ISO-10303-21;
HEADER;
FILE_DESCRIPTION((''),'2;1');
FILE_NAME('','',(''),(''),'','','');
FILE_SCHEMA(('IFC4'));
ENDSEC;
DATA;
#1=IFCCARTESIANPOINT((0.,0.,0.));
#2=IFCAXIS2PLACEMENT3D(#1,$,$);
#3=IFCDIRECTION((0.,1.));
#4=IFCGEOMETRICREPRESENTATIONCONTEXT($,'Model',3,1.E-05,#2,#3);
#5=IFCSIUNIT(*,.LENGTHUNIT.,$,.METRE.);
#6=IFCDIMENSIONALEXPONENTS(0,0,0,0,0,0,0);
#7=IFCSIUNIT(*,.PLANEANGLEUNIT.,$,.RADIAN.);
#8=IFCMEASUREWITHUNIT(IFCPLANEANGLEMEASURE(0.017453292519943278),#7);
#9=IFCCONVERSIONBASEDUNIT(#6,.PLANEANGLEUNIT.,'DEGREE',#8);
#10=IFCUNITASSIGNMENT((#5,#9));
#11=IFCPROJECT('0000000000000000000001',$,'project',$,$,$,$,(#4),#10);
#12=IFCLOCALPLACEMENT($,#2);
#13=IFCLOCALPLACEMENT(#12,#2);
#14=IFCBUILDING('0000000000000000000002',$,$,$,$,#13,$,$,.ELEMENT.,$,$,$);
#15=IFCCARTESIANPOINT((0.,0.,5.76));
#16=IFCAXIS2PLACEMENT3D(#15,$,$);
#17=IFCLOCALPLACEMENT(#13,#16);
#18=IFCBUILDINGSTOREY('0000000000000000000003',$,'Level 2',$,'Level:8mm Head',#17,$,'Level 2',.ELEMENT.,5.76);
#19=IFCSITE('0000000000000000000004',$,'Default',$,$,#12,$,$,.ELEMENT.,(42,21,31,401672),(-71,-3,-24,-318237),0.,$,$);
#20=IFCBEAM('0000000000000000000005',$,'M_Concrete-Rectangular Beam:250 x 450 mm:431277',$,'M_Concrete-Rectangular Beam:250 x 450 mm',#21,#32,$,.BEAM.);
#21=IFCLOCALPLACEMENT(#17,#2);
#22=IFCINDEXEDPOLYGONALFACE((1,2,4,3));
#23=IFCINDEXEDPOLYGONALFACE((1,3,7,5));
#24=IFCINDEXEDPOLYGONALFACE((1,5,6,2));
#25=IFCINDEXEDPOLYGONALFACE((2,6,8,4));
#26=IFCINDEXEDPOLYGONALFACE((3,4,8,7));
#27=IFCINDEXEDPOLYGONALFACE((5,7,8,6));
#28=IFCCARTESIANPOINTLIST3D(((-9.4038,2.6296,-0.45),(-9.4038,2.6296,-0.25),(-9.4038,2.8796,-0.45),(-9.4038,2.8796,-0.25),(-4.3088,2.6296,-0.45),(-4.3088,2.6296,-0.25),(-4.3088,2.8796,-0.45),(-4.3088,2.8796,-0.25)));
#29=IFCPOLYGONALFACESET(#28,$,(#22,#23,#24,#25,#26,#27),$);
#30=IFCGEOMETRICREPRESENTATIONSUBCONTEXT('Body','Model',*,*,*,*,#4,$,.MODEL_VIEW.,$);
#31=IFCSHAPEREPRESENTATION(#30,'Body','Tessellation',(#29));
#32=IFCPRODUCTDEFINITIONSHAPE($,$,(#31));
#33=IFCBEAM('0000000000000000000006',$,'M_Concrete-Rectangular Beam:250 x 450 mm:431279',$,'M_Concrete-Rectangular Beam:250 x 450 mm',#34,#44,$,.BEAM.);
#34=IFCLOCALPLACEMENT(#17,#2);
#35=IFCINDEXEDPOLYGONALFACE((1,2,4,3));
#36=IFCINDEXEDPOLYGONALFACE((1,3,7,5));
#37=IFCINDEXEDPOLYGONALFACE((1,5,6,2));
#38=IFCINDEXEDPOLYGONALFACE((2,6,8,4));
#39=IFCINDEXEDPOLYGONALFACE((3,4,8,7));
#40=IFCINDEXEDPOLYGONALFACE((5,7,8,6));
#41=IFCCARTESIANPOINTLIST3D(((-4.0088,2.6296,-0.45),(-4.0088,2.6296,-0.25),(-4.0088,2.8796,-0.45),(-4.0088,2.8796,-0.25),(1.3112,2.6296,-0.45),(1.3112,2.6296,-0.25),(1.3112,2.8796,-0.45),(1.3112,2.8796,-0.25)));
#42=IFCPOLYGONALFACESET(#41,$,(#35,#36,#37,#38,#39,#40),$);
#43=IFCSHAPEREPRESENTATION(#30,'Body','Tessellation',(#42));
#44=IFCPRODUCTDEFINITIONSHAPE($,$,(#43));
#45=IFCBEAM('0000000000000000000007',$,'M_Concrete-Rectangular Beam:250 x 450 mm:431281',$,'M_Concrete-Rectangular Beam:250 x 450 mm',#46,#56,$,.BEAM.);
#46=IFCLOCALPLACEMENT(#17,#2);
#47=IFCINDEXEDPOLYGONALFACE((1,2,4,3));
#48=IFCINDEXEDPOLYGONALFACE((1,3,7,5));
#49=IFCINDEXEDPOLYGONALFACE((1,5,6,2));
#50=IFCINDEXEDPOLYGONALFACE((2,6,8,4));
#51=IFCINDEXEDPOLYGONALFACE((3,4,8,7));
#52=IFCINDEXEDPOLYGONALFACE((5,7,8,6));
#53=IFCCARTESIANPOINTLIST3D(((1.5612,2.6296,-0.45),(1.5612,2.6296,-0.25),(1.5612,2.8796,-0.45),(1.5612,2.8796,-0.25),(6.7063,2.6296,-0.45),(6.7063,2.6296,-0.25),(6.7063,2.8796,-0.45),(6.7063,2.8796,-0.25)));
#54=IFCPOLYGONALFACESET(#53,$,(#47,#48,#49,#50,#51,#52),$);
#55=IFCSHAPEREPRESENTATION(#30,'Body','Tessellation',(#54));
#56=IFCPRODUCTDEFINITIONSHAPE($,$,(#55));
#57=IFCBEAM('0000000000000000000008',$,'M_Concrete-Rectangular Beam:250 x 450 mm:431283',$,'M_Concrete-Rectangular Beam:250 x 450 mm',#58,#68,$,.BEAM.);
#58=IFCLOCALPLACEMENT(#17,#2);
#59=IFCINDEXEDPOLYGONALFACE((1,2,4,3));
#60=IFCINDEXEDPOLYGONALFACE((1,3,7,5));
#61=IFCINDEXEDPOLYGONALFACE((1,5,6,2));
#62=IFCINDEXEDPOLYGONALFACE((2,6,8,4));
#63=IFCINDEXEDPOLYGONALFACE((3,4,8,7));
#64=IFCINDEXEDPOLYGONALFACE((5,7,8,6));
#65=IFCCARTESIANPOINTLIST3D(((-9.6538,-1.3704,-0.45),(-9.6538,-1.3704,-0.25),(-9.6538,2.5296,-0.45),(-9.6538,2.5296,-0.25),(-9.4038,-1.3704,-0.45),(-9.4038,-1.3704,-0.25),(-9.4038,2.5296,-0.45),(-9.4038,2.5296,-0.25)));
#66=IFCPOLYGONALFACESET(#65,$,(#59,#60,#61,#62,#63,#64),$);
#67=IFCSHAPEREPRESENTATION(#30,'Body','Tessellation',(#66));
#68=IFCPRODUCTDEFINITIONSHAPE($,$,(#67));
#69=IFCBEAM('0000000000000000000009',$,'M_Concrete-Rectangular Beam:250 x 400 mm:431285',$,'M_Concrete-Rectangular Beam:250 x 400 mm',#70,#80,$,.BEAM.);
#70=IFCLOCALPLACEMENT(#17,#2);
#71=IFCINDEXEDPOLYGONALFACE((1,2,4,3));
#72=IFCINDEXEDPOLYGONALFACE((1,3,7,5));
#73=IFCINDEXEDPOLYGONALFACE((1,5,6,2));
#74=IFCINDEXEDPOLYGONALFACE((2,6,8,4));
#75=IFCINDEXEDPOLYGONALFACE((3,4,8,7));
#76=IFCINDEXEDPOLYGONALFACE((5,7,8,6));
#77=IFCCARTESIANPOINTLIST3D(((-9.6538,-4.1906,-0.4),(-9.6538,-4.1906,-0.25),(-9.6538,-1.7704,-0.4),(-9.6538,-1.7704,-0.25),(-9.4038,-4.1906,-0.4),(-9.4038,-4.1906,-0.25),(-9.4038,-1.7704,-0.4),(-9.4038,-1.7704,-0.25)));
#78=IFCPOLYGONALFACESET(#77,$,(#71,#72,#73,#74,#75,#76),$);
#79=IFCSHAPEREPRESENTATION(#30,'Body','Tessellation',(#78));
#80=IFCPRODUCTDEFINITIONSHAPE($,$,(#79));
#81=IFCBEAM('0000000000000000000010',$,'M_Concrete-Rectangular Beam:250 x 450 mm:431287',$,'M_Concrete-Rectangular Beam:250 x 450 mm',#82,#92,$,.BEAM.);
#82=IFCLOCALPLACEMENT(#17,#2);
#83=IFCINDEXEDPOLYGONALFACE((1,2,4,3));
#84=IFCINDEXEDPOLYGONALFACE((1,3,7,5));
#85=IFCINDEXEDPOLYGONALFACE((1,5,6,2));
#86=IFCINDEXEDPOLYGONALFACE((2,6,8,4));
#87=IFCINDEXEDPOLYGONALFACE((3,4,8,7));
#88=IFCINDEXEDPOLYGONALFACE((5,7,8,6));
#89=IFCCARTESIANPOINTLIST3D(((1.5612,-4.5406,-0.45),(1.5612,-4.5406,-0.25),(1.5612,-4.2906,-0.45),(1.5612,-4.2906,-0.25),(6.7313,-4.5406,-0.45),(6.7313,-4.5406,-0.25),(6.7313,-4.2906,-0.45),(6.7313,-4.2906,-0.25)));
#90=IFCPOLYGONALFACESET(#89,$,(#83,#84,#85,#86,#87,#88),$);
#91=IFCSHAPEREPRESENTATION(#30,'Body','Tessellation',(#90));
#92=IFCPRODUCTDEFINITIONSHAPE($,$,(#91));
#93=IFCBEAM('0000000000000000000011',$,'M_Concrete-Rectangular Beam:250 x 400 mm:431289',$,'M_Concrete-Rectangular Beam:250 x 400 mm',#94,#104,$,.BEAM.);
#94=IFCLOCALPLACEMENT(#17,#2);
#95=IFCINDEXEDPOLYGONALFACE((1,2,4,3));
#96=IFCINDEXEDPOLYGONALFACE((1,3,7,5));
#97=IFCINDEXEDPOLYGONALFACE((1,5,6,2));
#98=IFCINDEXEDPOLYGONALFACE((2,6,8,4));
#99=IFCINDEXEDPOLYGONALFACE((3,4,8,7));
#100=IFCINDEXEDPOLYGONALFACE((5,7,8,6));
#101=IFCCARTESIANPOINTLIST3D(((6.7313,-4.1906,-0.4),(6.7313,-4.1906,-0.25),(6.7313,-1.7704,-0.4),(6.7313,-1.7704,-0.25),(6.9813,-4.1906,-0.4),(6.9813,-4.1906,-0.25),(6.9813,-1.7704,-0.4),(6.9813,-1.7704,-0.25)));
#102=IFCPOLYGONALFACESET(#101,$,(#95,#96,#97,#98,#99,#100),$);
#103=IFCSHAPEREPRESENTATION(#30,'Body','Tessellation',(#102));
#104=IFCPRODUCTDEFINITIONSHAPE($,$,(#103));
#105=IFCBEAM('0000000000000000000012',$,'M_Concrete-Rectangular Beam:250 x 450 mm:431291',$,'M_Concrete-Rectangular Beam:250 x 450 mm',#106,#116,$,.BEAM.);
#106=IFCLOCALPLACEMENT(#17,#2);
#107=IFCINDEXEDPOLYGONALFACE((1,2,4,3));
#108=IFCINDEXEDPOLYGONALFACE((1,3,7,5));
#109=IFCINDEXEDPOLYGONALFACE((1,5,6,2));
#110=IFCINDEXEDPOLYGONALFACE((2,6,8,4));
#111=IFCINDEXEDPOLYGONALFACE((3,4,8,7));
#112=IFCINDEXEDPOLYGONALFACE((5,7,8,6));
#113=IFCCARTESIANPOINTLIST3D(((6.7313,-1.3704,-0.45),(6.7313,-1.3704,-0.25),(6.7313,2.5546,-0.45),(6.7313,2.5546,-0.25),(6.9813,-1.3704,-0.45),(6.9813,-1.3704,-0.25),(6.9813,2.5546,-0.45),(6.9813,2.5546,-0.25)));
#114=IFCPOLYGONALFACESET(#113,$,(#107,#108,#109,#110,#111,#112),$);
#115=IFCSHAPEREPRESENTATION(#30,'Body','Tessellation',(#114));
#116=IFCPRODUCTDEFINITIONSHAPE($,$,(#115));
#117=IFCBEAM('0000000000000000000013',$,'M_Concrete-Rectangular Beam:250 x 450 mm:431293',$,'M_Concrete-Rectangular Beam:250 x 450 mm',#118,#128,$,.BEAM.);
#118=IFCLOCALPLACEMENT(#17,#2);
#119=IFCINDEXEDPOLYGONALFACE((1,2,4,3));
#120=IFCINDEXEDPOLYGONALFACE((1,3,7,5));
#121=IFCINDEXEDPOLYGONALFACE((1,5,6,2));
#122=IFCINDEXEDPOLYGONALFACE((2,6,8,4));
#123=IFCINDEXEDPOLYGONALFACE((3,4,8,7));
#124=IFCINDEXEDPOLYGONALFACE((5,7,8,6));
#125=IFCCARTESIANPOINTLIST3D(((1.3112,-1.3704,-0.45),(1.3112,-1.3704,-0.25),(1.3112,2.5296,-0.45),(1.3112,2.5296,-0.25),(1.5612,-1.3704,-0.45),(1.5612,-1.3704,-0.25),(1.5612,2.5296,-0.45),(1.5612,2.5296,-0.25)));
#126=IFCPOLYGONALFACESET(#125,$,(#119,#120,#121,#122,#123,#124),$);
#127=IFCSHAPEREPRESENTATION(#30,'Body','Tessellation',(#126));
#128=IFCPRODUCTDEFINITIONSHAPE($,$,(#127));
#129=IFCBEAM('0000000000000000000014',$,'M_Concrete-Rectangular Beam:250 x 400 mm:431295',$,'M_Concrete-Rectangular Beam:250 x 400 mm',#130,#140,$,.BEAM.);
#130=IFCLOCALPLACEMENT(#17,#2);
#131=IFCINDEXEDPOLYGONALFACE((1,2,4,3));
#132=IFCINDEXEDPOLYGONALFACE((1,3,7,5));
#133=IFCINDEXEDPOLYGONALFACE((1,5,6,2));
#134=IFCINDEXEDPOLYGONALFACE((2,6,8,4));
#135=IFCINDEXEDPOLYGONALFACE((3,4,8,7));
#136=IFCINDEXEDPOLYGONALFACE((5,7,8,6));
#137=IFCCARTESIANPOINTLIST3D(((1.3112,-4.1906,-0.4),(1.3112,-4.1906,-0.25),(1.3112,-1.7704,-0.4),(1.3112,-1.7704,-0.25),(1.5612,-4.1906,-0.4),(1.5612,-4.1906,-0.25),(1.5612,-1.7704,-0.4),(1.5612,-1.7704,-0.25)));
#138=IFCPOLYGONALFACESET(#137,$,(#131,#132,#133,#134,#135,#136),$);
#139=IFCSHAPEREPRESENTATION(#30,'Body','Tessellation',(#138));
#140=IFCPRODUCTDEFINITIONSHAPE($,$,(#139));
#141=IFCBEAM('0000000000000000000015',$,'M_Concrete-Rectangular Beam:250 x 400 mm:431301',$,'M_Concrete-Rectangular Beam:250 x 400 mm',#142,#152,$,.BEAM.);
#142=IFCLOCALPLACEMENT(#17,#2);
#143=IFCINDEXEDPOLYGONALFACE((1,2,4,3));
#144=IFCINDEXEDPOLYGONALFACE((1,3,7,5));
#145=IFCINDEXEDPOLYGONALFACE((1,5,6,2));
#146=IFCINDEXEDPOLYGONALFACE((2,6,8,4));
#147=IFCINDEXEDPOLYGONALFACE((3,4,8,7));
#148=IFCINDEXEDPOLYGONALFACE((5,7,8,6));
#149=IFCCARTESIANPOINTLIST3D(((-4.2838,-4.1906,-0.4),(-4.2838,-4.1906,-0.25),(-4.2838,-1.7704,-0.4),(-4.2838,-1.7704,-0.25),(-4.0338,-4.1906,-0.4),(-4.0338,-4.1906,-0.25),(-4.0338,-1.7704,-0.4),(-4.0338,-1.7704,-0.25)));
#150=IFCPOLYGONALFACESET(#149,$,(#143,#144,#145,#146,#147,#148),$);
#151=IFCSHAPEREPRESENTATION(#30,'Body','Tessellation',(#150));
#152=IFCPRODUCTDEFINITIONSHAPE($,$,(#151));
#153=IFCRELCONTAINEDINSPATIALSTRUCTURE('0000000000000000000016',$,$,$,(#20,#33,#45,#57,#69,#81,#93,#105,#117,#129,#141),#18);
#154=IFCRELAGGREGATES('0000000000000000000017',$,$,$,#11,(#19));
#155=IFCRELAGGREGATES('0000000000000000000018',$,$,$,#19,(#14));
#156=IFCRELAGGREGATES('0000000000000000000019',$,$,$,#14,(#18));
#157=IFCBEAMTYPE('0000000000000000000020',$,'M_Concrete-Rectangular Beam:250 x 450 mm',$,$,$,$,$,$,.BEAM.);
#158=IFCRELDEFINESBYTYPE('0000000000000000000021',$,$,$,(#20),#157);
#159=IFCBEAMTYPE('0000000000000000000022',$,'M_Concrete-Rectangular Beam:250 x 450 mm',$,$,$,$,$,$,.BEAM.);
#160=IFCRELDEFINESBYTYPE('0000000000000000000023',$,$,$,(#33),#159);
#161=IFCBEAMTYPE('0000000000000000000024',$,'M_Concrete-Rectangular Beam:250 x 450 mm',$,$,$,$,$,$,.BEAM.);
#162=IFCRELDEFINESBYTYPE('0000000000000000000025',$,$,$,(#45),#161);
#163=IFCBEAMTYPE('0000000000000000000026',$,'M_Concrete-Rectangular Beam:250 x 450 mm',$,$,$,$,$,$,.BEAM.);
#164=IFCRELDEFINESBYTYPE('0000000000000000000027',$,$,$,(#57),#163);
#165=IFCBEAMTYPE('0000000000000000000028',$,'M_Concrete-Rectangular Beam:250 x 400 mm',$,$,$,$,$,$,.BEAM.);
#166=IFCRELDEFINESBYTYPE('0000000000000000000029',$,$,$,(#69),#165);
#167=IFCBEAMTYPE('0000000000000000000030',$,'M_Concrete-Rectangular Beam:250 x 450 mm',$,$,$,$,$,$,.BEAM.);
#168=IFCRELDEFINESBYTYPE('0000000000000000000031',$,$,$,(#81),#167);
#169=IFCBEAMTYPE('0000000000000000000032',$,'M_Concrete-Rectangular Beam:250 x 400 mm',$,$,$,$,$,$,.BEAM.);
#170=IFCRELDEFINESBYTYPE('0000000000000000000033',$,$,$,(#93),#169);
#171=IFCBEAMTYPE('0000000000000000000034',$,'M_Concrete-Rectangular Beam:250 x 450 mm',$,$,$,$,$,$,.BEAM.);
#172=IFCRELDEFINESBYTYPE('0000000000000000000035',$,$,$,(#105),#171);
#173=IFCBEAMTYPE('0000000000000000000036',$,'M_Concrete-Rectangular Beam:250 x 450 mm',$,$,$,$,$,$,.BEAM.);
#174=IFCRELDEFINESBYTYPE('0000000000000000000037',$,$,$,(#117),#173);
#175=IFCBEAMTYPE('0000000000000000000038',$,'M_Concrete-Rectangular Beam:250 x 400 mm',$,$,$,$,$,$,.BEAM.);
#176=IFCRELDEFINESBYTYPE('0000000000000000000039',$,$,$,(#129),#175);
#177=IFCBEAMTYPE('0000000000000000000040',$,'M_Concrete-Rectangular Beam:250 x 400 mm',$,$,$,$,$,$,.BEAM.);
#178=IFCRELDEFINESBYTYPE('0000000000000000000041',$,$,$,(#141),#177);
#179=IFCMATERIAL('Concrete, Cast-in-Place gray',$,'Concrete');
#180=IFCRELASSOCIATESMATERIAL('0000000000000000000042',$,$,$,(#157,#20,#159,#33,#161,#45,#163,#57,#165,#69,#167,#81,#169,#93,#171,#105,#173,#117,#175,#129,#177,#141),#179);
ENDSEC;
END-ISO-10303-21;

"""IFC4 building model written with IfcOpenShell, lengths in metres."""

from ifc_helpers import new_model, entity, si_unit, converted_unit, direction, frame, origin, place, context, subcontext, project, spatial, indexed_curve, outline, extrude, source, transform, mapped, material, type_object, type_shapes, element, save


model = new_model("IFC4")

# Units and contexts
model_context = context("Model", 3, precision=1e-05, world=origin(), true_north=direction((0.0, 1.0)))
body_context = subcontext(model_context, "Body", "Model", "MODEL_VIEW")
ifc_project = project(units=[si_unit("LENGTHUNIT", "METRE"), converted_unit("PLANEANGLEUNIT", "DEGREE", entity("IfcPlaneAngleMeasure", 0.017453292519943278), si_unit("PLANEANGLEUNIT", "RADIAN"), dimensions=[0, 0, 0, 0, 0, 0, 0])], contexts=[model_context])

# Site, building, storey
site_placement = place(None, origin())
site = spatial("IfcSite", under=ifc_project, at=site_placement, Name="Default", CompositionType="ELEMENT", RefLatitude=(42, 21, 31, 401672), RefLongitude=(-71, -3, -24, -318237), RefElevation=0.0)
building_placement = place(site_placement, origin())
building = spatial("IfcBuilding", under=site, at=building_placement, CompositionType="ELEMENT")
storey_placement = place(building_placement, frame((0.0, 0.0, 5.76)))
storey = spatial("IfcBuildingStorey", under=building, at=storey_placement, Name="Level 2", ObjectType="Level:8mm Head", LongName="Level 2", CompositionType="ELEMENT", Elevation=5.76)

# Beams
ifc_material = material(Name="Concrete, Cast-in-Place gray", Category="Concrete")
beam_type_1 = type_object("IfcBeamType", Name="M_Concrete-Rectangular Beam:250 x 450 mm", PredefinedType="BEAM", material=ifc_material)
shared_shape_1 = source(origin(), body_context, "Body", "SweptSolid", [
    extrude(outline(indexed_curve([(-0.1, -0.125), (0.1, -0.125), (0.1, 0.125), (-0.1, 0.125), (-0.1, -0.125)], self_intersect=False)), frame((-9.4038, 2.7546, 5.41), z_axis=(1.0, 0.0, 0.0), x_axis=(0.0, 0.0, -1.0)), (0.0, 0.0, 1.0), 5.095),
])
type_shapes(beam_type_1, [shared_shape_1])
beam_1_placement = place(storey_placement, frame((0.0, 0.0, -5.76)))
element("IfcBeam", 1, at=beam_1_placement, inside=storey, type_object=beam_type_1, material=ifc_material, Name="M_Concrete-Rectangular Beam:250 x 450 mm:431277", ObjectType="M_Concrete-Rectangular Beam:250 x 450 mm", PredefinedType="BEAM", context=body_context, shape_type="MappedRepresentation", body=[
    mapped(shared_shape_1, transform((0.0, 0.0, 0.0), scale=1.0)),
])
beam_type_2 = type_object("IfcBeamType", Name="M_Concrete-Rectangular Beam:250 x 450 mm", PredefinedType="BEAM", material=ifc_material)
shared_shape_2 = source(origin(), body_context, "Body", "SweptSolid", [
    extrude(outline(indexed_curve([(-0.1, -0.125), (0.1, -0.125), (0.1, 0.125), (-0.1, 0.125), (-0.1, -0.125)], self_intersect=False)), frame((-4.0088, 2.7546, 5.41), z_axis=(1.0, 0.0, 0.0), x_axis=(0.0, 0.0, -1.0)), (0.0, 0.0, 1.0), 5.32),
])
type_shapes(beam_type_2, [shared_shape_2])
beam_2_placement = place(storey_placement, frame((0.0, 0.0, -5.76)))
element("IfcBeam", 2, at=beam_2_placement, inside=storey, type_object=beam_type_2, material=ifc_material, Name="M_Concrete-Rectangular Beam:250 x 450 mm:431279", ObjectType="M_Concrete-Rectangular Beam:250 x 450 mm", PredefinedType="BEAM", context=body_context, shape_type="MappedRepresentation", body=[
    mapped(shared_shape_2, transform((0.0, 0.0, 0.0), scale=1.0)),
])
beam_type_3 = type_object("IfcBeamType", Name="M_Concrete-Rectangular Beam:250 x 450 mm", PredefinedType="BEAM", material=ifc_material)
shared_shape_3 = source(origin(), body_context, "Body", "SweptSolid", [
    extrude(outline(indexed_curve([(-0.1, -0.125), (0.1, -0.125), (0.1, 0.125), (-0.1, 0.125), (-0.1, -0.125)], self_intersect=False)), frame((1.5612, 2.7546, 5.41), z_axis=(1.0, 0.0, 0.0), x_axis=(0.0, 0.0, -1.0)), (0.0, 0.0, 1.0), 5.1451),
])
type_shapes(beam_type_3, [shared_shape_3])
beam_3_placement = place(storey_placement, frame((0.0, 0.0, -5.76)))
element("IfcBeam", 3, at=beam_3_placement, inside=storey, type_object=beam_type_3, material=ifc_material, Name="M_Concrete-Rectangular Beam:250 x 450 mm:431281", ObjectType="M_Concrete-Rectangular Beam:250 x 450 mm", PredefinedType="BEAM", context=body_context, shape_type="MappedRepresentation", body=[
    mapped(shared_shape_3, transform((0.0, 0.0, 0.0), scale=1.0)),
])
beam_type_4 = type_object("IfcBeamType", Name="M_Concrete-Rectangular Beam:250 x 450 mm", PredefinedType="BEAM", material=ifc_material)
shared_shape_4 = source(origin(), body_context, "Body", "SweptSolid", [
    extrude(outline(indexed_curve([(-0.125, -0.1), (0.125, -0.1), (0.125, 0.1), (-0.125, 0.1), (-0.125, -0.1)], self_intersect=False)), frame((-9.5288, 2.5296, 5.41), z_axis=(0.0, -1.0, 0.0), x_axis=(-1.0, 0.0, 0.0)), (0.0, 0.0, 1.0), 3.9),
])
type_shapes(beam_type_4, [shared_shape_4])
beam_4_placement = place(storey_placement, frame((0.0, 0.0, -5.76)))
element("IfcBeam", 4, at=beam_4_placement, inside=storey, type_object=beam_type_4, material=ifc_material, Name="M_Concrete-Rectangular Beam:250 x 450 mm:431283", ObjectType="M_Concrete-Rectangular Beam:250 x 450 mm", PredefinedType="BEAM", context=body_context, shape_type="MappedRepresentation", body=[
    mapped(shared_shape_4, transform((0.0, 0.0, 0.0), scale=1.0)),
])
beam_type_5 = type_object("IfcBeamType", Name="M_Concrete-Rectangular Beam:250 x 400 mm", PredefinedType="BEAM", material=ifc_material)
shared_shape_5 = source(origin(), body_context, "Body", "SweptSolid", [
    extrude(outline(indexed_curve([(-0.125, -0.075), (0.125, -0.075), (0.125, 0.075), (-0.125, 0.075), (-0.125, -0.075)], self_intersect=False)), frame((-9.5288, -1.7704, 5.435), z_axis=(0.0, -1.0, 0.0), x_axis=(-1.0, 0.0, 0.0)), (0.0, 0.0, 1.0), 2.4202),
])
type_shapes(beam_type_5, [shared_shape_5])
beam_5_placement = place(storey_placement, frame((0.0, 0.0, -5.76)))
element("IfcBeam", 5, at=beam_5_placement, inside=storey, type_object=beam_type_5, material=ifc_material, Name="M_Concrete-Rectangular Beam:250 x 400 mm:431285", ObjectType="M_Concrete-Rectangular Beam:250 x 400 mm", PredefinedType="BEAM", context=body_context, shape_type="MappedRepresentation", body=[
    mapped(shared_shape_5, transform((0.0, 0.0, 0.0), scale=1.0)),
])
beam_type_6 = type_object("IfcBeamType", Name="M_Concrete-Rectangular Beam:250 x 450 mm", PredefinedType="BEAM", material=ifc_material)
shared_shape_6 = source(origin(), body_context, "Body", "SweptSolid", [
    extrude(outline(indexed_curve([(-0.1, -0.125), (0.1, -0.125), (0.1, 0.125), (-0.1, 0.125), (-0.1, -0.125)], self_intersect=False)), frame((1.5612, -4.4156, 5.41), z_axis=(1.0, 0.0, 0.0), x_axis=(0.0, 0.0, -1.0)), (0.0, 0.0, 1.0), 5.1701),
])
type_shapes(beam_type_6, [shared_shape_6])
beam_6_placement = place(storey_placement, frame((0.0, 0.0, -5.76)))
element("IfcBeam", 6, at=beam_6_placement, inside=storey, type_object=beam_type_6, material=ifc_material, Name="M_Concrete-Rectangular Beam:250 x 450 mm:431287", ObjectType="M_Concrete-Rectangular Beam:250 x 450 mm", PredefinedType="BEAM", context=body_context, shape_type="MappedRepresentation", body=[
    mapped(shared_shape_6, transform((0.0, 0.0, 0.0), scale=1.0)),
])
beam_type_7 = type_object("IfcBeamType", Name="M_Concrete-Rectangular Beam:250 x 400 mm", PredefinedType="BEAM", material=ifc_material)
shared_shape_7 = source(origin(), body_context, "Body", "SweptSolid", [
    extrude(outline(indexed_curve([(-0.125, -0.075), (0.125, -0.075), (0.125, 0.075), (-0.125, 0.075), (-0.125, -0.075)], self_intersect=False)), frame((6.8563, -4.1906, 5.435), z_axis=(0.0, 1.0, 0.0), x_axis=(-1.0, 0.0, 0.0)), (0.0, 0.0, 1.0), 2.4202),
])
type_shapes(beam_type_7, [shared_shape_7])
beam_7_placement = place(storey_placement, frame((0.0, 0.0, -5.76)))
element("IfcBeam", 7, at=beam_7_placement, inside=storey, type_object=beam_type_7, material=ifc_material, Name="M_Concrete-Rectangular Beam:250 x 400 mm:431289", ObjectType="M_Concrete-Rectangular Beam:250 x 400 mm", PredefinedType="BEAM", context=body_context, shape_type="MappedRepresentation", body=[
    mapped(shared_shape_7, transform((0.0, 0.0, 0.0), scale=1.0)),
])
beam_type_8 = type_object("IfcBeamType", Name="M_Concrete-Rectangular Beam:250 x 450 mm", PredefinedType="BEAM", material=ifc_material)
shared_shape_8 = source(origin(), body_context, "Body", "SweptSolid", [
    extrude(outline(indexed_curve([(-0.125, -0.1), (0.125, -0.1), (0.125, 0.1), (-0.125, 0.1), (-0.125, -0.1)], self_intersect=False)), frame((6.8563, -1.3704, 5.41), z_axis=(0.0, 1.0, 0.0), x_axis=(-1.0, 0.0, 0.0)), (0.0, 0.0, 1.0), 3.925),
])
type_shapes(beam_type_8, [shared_shape_8])
beam_8_placement = place(storey_placement, frame((0.0, 0.0, -5.76)))
element("IfcBeam", 8, at=beam_8_placement, inside=storey, type_object=beam_type_8, material=ifc_material, Name="M_Concrete-Rectangular Beam:250 x 450 mm:431291", ObjectType="M_Concrete-Rectangular Beam:250 x 450 mm", PredefinedType="BEAM", context=body_context, shape_type="MappedRepresentation", body=[
    mapped(shared_shape_8, transform((0.0, 0.0, 0.0), scale=1.0)),
])
beam_type_9 = type_object("IfcBeamType", Name="M_Concrete-Rectangular Beam:250 x 450 mm", PredefinedType="BEAM", material=ifc_material)
shared_shape_9 = source(origin(), body_context, "Body", "SweptSolid", [
    extrude(outline(indexed_curve([(-0.125, -0.1), (0.125, -0.1), (0.125, 0.1), (-0.125, 0.1), (-0.125, -0.1)], self_intersect=False)), frame((1.4362, -1.3704, 5.41), z_axis=(0.0, 1.0, 0.0), x_axis=(-1.0, 0.0, 0.0)), (0.0, 0.0, 1.0), 3.9),
])
type_shapes(beam_type_9, [shared_shape_9])
beam_9_placement = place(storey_placement, frame((0.0, 0.0, -5.76)))
element("IfcBeam", 9, at=beam_9_placement, inside=storey, type_object=beam_type_9, material=ifc_material, Name="M_Concrete-Rectangular Beam:250 x 450 mm:431293", ObjectType="M_Concrete-Rectangular Beam:250 x 450 mm", PredefinedType="BEAM", context=body_context, shape_type="MappedRepresentation", body=[
    mapped(shared_shape_9, transform((0.0, 0.0, 0.0), scale=1.0)),
])
beam_type_10 = type_object("IfcBeamType", Name="M_Concrete-Rectangular Beam:250 x 400 mm", PredefinedType="BEAM", material=ifc_material)
shared_shape_10 = source(origin(), body_context, "Body", "SweptSolid", [
    extrude(outline(indexed_curve([(-0.125, -0.075), (0.125, -0.075), (0.125, 0.075), (-0.125, 0.075), (-0.125, -0.075)], self_intersect=False)), frame((1.4362, -1.7704, 5.435), z_axis=(0.0, -1.0, 0.0), x_axis=(-1.0, 0.0, 0.0)), (0.0, 0.0, 1.0), 2.4202),
])
type_shapes(beam_type_10, [shared_shape_10])
beam_10_placement = place(storey_placement, frame((0.0, 0.0, -5.76)))
element("IfcBeam", 10, at=beam_10_placement, inside=storey, type_object=beam_type_10, material=ifc_material, Name="M_Concrete-Rectangular Beam:250 x 400 mm:431295", ObjectType="M_Concrete-Rectangular Beam:250 x 400 mm", PredefinedType="BEAM", context=body_context, shape_type="MappedRepresentation", body=[
    mapped(shared_shape_10, transform((0.0, 0.0, 0.0), scale=1.0)),
])
beam_type_11 = type_object("IfcBeamType", Name="M_Concrete-Rectangular Beam:250 x 400 mm", PredefinedType="BEAM", material=ifc_material)
shared_shape_11 = source(origin(), body_context, "Body", "SweptSolid", [
    extrude(outline(indexed_curve([(-0.125, -0.075), (0.125, -0.075), (0.125, 0.075), (-0.125, 0.075), (-0.125, -0.075)], self_intersect=False)), frame((-4.1588, -1.7704, 5.435), z_axis=(0.0, -1.0, 0.0), x_axis=(-1.0, 0.0, 0.0)), (0.0, 0.0, 1.0), 2.4202),
])
type_shapes(beam_type_11, [shared_shape_11])
beam_11_placement = place(storey_placement, frame((0.0, 0.0, -5.76)))
element("IfcBeam", 11, at=beam_11_placement, inside=storey, type_object=beam_type_11, material=ifc_material, Name="M_Concrete-Rectangular Beam:250 x 400 mm:431301", ObjectType="M_Concrete-Rectangular Beam:250 x 400 mm", PredefinedType="BEAM", context=body_context, shape_type="MappedRepresentation", body=[
    mapped(shared_shape_11, transform((0.0, 0.0, 0.0), scale=1.0)),
])

save(model, "model.ifc")
